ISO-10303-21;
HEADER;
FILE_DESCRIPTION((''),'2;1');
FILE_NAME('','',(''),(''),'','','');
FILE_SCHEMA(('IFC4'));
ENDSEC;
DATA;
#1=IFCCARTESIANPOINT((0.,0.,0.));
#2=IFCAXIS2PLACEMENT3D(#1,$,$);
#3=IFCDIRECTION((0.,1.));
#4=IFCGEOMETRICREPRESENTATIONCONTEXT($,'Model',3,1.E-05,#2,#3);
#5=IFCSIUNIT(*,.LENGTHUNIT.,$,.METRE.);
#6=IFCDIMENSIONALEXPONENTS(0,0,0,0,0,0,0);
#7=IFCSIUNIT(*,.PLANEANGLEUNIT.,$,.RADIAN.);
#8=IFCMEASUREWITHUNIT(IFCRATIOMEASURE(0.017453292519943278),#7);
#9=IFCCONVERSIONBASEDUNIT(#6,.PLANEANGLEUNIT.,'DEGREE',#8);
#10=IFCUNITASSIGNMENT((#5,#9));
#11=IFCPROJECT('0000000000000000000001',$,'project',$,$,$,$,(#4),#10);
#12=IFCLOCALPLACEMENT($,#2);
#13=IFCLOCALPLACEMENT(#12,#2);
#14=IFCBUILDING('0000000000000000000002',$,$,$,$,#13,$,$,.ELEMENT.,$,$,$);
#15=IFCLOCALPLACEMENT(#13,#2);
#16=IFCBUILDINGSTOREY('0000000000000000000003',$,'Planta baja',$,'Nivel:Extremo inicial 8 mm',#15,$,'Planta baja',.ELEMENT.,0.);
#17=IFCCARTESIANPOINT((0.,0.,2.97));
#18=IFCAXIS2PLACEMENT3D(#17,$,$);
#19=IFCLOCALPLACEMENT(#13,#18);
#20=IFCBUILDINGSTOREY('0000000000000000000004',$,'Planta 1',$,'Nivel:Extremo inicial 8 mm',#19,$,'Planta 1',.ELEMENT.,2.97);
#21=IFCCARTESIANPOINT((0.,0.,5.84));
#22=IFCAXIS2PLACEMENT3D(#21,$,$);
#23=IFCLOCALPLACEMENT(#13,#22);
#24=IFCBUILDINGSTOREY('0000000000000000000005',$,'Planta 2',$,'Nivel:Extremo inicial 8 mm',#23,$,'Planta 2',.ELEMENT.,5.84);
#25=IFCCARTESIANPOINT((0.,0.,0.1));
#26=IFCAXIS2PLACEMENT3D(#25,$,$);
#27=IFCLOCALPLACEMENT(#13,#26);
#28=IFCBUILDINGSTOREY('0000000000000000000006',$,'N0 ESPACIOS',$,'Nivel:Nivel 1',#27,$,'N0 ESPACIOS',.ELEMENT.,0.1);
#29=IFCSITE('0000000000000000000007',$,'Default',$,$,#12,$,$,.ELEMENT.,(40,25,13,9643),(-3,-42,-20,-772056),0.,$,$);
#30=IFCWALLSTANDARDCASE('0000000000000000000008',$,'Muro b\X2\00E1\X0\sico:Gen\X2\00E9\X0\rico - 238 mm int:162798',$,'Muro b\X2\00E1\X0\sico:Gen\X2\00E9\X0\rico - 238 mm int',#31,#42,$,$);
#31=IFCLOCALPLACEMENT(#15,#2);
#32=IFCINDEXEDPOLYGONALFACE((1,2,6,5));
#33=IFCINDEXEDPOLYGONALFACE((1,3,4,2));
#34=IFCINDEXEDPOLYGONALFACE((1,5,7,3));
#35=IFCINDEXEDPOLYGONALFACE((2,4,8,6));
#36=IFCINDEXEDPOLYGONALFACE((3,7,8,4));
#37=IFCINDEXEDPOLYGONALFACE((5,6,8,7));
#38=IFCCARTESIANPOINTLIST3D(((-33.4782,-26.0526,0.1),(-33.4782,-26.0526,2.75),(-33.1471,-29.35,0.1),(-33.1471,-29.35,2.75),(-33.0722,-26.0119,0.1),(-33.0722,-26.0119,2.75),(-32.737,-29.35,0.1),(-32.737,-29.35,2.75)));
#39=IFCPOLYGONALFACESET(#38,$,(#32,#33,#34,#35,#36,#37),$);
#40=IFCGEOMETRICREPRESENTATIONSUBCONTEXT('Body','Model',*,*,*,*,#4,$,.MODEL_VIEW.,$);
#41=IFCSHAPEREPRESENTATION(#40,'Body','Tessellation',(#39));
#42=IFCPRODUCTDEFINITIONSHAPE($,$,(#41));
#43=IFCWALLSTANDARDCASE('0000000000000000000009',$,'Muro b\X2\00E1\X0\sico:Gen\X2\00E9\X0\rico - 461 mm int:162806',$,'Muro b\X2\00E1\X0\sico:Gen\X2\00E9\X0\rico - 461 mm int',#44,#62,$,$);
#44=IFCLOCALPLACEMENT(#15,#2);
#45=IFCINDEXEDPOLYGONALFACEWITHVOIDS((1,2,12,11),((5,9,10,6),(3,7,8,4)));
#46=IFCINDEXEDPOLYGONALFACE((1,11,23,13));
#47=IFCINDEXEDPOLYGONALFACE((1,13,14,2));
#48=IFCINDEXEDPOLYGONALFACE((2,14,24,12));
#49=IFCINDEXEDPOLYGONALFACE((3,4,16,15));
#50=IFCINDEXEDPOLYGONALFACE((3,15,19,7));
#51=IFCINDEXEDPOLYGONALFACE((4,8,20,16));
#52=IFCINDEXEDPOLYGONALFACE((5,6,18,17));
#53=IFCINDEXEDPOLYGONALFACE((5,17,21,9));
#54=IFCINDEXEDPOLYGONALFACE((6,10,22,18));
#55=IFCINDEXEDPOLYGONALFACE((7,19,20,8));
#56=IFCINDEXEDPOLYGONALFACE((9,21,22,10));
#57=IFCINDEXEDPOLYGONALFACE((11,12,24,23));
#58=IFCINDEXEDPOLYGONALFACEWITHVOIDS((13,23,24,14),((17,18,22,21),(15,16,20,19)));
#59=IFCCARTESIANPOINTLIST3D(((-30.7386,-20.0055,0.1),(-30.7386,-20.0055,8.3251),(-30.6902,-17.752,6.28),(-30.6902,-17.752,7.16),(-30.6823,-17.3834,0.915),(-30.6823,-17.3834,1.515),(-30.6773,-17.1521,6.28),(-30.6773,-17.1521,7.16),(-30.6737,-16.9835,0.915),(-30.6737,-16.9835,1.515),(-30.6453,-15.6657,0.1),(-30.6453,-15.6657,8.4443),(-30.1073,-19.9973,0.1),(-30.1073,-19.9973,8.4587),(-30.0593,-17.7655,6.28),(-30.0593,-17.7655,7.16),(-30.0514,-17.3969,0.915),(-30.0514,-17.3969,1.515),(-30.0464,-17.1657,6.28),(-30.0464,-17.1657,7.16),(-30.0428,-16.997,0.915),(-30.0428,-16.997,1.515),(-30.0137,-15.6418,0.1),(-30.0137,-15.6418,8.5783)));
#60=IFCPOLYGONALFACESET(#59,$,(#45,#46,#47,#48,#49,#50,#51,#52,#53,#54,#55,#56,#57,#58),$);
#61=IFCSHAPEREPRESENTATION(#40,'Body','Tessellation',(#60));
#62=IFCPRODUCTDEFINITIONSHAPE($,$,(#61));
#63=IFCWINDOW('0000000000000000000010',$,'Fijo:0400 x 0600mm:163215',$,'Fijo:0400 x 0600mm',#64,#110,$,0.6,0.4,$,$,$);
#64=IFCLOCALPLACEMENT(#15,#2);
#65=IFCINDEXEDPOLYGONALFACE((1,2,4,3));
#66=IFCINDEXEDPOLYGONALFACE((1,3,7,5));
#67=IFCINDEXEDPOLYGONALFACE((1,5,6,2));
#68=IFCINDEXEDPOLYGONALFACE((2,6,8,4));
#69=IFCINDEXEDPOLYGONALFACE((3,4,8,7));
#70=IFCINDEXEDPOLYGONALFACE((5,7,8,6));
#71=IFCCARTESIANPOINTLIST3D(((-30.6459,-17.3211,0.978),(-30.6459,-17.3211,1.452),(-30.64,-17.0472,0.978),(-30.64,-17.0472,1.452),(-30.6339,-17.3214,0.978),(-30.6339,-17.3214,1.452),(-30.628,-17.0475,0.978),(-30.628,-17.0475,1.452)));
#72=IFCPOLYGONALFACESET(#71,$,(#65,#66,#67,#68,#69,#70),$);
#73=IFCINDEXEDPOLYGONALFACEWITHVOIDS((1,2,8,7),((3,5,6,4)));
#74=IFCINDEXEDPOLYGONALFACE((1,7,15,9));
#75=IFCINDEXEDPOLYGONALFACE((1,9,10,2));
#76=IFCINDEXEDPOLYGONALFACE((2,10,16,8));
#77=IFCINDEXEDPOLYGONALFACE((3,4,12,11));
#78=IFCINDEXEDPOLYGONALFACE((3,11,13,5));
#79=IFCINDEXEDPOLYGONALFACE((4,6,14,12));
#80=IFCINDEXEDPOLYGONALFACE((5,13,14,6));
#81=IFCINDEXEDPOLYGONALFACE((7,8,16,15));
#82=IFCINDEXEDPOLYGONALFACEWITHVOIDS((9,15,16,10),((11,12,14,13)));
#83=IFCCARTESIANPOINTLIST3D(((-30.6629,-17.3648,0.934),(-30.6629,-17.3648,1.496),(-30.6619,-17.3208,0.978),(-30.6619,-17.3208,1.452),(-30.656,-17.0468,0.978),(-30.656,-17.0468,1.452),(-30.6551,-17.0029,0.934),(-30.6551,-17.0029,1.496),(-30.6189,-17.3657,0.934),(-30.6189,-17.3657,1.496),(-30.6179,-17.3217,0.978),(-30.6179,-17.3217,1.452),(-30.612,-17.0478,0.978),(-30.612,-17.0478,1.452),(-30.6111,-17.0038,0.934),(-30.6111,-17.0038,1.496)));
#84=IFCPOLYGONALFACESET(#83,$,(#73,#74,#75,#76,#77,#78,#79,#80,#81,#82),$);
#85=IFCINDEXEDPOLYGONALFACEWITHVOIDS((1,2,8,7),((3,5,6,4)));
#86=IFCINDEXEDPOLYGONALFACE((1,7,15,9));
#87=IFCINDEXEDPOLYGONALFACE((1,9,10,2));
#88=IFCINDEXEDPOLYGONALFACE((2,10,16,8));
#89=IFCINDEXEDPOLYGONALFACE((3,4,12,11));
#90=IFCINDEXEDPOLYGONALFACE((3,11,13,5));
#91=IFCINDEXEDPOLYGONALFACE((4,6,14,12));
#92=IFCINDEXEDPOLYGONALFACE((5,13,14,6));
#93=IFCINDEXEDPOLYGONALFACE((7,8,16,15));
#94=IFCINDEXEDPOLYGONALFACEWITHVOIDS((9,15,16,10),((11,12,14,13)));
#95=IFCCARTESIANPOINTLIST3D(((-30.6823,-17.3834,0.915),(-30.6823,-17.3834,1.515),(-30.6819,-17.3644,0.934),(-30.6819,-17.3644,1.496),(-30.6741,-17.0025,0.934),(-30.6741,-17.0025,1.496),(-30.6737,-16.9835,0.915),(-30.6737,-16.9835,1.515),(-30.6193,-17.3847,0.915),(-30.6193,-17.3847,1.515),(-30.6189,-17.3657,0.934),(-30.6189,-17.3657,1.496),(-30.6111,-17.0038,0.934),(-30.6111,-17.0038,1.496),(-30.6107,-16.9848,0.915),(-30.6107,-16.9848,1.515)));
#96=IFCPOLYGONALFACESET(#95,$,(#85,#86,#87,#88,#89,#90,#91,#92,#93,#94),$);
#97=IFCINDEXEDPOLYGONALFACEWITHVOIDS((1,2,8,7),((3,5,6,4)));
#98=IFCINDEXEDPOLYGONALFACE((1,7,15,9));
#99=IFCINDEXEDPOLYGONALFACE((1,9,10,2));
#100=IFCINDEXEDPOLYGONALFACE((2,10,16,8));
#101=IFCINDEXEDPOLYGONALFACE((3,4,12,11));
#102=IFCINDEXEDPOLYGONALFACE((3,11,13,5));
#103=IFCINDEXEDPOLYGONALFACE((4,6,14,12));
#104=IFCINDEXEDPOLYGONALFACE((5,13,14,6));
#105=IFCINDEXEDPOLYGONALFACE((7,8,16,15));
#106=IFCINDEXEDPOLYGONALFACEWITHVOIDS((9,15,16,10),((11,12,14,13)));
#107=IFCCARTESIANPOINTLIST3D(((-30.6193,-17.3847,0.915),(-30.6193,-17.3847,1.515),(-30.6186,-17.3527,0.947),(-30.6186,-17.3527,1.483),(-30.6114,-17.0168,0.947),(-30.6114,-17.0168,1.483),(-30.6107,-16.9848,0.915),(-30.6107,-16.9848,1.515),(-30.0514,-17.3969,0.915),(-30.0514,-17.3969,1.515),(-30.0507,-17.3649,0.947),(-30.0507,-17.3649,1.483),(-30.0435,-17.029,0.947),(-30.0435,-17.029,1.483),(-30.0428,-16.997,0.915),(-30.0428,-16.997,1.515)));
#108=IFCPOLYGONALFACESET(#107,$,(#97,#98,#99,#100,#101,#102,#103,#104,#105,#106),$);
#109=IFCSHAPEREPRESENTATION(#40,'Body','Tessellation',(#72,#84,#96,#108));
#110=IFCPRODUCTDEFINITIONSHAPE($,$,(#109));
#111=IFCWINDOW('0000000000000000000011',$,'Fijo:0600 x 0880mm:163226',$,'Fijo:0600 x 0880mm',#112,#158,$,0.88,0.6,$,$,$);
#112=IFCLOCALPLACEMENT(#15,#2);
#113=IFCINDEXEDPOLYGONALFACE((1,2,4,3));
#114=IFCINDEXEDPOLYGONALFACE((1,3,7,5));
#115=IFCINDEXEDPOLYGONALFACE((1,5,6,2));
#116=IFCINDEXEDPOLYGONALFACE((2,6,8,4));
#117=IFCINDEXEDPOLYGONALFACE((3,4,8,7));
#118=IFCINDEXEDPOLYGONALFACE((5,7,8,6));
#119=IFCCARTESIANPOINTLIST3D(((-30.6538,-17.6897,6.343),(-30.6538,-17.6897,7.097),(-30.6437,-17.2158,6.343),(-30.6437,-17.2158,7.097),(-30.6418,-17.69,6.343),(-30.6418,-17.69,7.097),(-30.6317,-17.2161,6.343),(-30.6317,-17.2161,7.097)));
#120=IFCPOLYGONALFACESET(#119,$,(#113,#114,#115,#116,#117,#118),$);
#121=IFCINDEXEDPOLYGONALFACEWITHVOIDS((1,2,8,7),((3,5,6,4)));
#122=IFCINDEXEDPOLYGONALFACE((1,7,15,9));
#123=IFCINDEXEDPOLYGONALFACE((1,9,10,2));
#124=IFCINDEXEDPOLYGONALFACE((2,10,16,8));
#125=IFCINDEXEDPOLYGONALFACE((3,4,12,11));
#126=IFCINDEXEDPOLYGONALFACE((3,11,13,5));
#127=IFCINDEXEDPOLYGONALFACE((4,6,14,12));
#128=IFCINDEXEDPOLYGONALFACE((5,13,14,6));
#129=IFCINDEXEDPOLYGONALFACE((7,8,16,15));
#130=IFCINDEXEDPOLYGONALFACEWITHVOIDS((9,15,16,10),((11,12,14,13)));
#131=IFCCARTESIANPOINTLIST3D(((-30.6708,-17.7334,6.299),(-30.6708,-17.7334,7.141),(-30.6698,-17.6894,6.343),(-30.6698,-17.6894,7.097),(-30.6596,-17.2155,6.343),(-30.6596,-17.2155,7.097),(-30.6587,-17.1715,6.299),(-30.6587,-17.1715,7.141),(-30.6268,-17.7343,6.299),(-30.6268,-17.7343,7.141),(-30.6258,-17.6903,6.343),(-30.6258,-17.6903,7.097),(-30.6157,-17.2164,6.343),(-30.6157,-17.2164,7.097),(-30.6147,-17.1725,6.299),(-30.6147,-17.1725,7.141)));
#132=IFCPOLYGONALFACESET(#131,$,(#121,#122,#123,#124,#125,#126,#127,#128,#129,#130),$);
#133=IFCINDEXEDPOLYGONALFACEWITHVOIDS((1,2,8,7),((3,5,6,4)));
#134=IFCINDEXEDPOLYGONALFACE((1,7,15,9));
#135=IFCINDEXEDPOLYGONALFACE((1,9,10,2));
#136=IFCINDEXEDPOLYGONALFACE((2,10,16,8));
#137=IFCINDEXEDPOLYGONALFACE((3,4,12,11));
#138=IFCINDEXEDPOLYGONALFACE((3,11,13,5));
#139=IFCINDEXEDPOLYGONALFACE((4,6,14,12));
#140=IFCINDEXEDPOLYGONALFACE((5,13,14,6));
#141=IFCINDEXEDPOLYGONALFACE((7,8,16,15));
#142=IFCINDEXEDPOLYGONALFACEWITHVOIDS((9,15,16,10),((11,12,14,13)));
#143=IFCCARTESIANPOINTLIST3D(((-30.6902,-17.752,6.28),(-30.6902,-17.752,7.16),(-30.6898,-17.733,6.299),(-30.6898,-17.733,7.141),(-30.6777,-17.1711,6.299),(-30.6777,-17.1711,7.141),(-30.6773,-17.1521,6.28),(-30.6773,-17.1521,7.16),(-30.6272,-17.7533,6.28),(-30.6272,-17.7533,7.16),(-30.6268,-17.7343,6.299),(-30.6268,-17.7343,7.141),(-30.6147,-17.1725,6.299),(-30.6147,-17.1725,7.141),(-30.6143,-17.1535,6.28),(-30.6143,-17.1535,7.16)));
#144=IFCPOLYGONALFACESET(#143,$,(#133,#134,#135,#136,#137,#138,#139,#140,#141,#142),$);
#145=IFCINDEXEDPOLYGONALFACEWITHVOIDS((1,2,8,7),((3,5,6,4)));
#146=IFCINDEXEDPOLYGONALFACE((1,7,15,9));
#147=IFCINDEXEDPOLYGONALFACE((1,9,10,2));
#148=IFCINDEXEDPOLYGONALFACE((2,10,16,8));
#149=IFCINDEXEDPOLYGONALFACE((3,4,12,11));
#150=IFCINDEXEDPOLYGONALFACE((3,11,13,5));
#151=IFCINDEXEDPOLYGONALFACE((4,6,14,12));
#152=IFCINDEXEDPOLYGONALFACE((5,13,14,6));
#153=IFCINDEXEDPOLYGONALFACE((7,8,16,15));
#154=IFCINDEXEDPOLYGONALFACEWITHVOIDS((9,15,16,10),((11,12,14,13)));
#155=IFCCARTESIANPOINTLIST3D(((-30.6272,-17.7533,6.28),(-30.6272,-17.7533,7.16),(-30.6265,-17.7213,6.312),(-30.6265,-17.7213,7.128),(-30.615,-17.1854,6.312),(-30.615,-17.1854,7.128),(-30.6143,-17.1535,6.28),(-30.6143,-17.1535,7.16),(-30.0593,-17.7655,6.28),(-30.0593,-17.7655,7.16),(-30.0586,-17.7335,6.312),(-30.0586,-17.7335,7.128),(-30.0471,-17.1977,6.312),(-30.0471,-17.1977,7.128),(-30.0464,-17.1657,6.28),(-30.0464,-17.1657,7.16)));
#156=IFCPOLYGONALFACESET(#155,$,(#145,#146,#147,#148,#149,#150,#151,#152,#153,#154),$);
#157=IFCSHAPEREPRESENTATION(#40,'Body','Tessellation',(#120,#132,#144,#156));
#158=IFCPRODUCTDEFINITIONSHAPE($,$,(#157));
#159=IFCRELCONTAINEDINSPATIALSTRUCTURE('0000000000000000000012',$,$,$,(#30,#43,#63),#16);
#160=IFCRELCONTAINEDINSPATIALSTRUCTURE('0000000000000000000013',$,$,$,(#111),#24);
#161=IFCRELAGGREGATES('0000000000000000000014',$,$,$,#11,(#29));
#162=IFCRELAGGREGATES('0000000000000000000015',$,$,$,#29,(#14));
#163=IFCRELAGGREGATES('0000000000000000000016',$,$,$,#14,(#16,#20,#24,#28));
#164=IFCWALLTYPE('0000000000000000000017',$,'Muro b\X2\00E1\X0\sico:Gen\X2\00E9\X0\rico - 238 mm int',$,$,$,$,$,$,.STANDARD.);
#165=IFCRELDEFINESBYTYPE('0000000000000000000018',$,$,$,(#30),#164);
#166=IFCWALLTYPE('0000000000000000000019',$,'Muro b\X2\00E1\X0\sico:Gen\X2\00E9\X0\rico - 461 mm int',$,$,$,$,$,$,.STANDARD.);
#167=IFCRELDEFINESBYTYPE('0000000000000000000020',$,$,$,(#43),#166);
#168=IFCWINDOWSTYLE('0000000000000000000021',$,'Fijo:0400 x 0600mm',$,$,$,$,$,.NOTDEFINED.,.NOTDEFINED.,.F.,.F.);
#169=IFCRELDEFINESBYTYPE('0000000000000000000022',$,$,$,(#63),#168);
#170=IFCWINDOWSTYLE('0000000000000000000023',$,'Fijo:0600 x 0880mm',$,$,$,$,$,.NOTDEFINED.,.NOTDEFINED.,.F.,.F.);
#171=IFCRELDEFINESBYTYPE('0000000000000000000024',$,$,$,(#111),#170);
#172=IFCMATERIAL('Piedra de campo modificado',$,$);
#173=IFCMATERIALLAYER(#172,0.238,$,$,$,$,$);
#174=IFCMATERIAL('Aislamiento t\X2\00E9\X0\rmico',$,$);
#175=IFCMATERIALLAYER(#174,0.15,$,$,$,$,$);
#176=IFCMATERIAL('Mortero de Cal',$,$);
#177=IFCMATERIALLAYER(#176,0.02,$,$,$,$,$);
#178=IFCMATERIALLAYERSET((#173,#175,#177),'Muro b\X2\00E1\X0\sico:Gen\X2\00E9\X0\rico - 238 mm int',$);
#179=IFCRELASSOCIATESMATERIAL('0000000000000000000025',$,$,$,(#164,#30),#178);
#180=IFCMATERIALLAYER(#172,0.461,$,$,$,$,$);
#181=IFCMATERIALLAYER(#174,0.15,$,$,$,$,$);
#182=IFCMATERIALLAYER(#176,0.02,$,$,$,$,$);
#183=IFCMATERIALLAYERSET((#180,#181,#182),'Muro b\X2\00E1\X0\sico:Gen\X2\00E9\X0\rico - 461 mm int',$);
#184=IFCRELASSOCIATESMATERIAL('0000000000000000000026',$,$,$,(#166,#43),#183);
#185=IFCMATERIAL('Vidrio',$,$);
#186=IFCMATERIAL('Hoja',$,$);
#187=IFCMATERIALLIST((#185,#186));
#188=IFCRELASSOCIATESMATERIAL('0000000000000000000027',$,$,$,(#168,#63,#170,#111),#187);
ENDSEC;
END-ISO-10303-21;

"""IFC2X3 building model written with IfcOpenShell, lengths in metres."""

from ifc_helpers import new_model, entity, si_unit, converted_unit, direction, frame, frame_2d, origin, origin_2d_with_axis, place, context, subcontext, project, spatial, polyline, rectangle, outline, extrude, clip, bounded_halfspace, source, transform, mapped, material, material_list, layer, layer_set, layer_usage, type_object, type_shapes, element, fill, save


model = new_model("IFC2X3")

# Units and contexts
model_context = context("Model", 3, precision=1e-05, world=origin(), true_north=direction((0.0, 1.0)))
body_context = subcontext(model_context, "Body", "Model", "MODEL_VIEW")
ifc_project = project(units=[si_unit("LENGTHUNIT", "METRE"), converted_unit("PLANEANGLEUNIT", "DEGREE", entity("IfcRatioMeasure", 0.017453292519943278), si_unit("PLANEANGLEUNIT", "RADIAN"), dimensions=[0, 0, 0, 0, 0, 0, 0])], contexts=[model_context])

# Site, building, storey
site_placement = place(None, origin())
site = spatial("IfcSite", under=ifc_project, at=site_placement, Name="Default", CompositionType="ELEMENT", RefLatitude=(40, 25, 13, 9643), RefLongitude=(-3, -42, -20, -772056), RefElevation=0.0)
building_placement = place(site_placement, origin())
building = spatial("IfcBuilding", under=site, at=building_placement, CompositionType="ELEMENT")
storey_1_placement = place(building_placement, origin())
storey_1 = spatial("IfcBuildingStorey", under=building, at=storey_1_placement, Name="Planta baja", ObjectType="Nivel:Extremo inicial 8 mm", LongName="Planta baja", CompositionType="ELEMENT", Elevation=0.0)

# Shared definitions
ifc_material_1 = material(Name="Piedra de campo modificado")
ifc_material_2 = material(Name="Aislamiento térmico")
ifc_material_3 = material(Name="Mortero de Cal")

# Shared definitions
storey_2_placement = place(building_placement, frame((0.0, 0.0, 2.97)))
storey_2 = spatial("IfcBuildingStorey", under=building, at=storey_2_placement, Name="Planta 1", ObjectType="Nivel:Extremo inicial 8 mm", LongName="Planta 1", CompositionType="ELEMENT", Elevation=2.97)

# Shared definitions
ifc_material_4 = material(Name="Vidrio")
ifc_material_5 = material(Name="Hoja")
ifc_material_list_1 = material_list([ifc_material_4, ifc_material_5])

# Shared definitions
storey_3_placement = place(building_placement, frame((0.0, 0.0, 5.84)))
storey_3 = spatial("IfcBuildingStorey", under=building, at=storey_3_placement, Name="Planta 2", ObjectType="Nivel:Extremo inicial 8 mm", LongName="Planta 2", CompositionType="ELEMENT", Elevation=5.84)

# Wall
ifc_layer_1 = layer(ifc_material_1, 0.238)
ifc_layer_2 = layer(ifc_material_2, 0.15)
ifc_layer_3 = layer(ifc_material_3, 0.02)
ifc_layer_set_1 = layer_set([ifc_layer_1, ifc_layer_2, ifc_layer_3], Name="Muro básico:Genérico - 238 mm int")
ifc_layer_usage_1 = layer_usage(ifc_layer_set_1, "AXIS2", "NEGATIVE", 0.204)
wall_type_1 = type_object("IfcWallType", Name="Muro básico:Genérico - 238 mm int", PredefinedType="STANDARD", material=ifc_layer_set_1)
wall_1_placement = place(storey_1_placement, frame((-33.2752, -26.0322, 0.1), z_axis=(0.0, 0.0, 1.0), x_axis=(0.09992, -0.994996, 0.0)))
element("IfcWallStandardCase", 1, at=wall_1_placement, inside=storey_1, type_object=wall_type_1, material=ifc_layer_usage_1, Name="Muro básico:Genérico - 238 mm int:162798", ObjectType="Muro básico:Genérico - 238 mm int", context=body_context, shape_type="Clipping", body=[
    clip(extrude(outline(polyline([(3.314, -0.204), (3.355, 0.204), (2.8625, 0.204), (0.0, 0.204), (0.0, -0.204), (3.314, -0.204)])), origin(), (0.0, 0.0, 1.0), 2.65), bounded_halfspace(frame((0.0216, -0.204, 2.65), z_axis=(0.0, 0.0, -1.0), x_axis=(-1.0, 0.0, 0.0)), True, frame((0.0216, -0.204, 2.65)), polyline([(0.0, 0.0), (3.2924, 0.0), (3.3334, 0.408), (2.8409, 0.408), (0.0485, 0.408), (0.0, 0.0)]))),
])

# Shared definitions
storey_4_placement = place(building_placement, frame((0.0, 0.0, 0.1)))
storey_4 = spatial("IfcBuildingStorey", under=building, at=storey_4_placement, Name="N0 ESPACIOS", ObjectType="Nivel:Nivel 1", LongName="N0 ESPACIOS", CompositionType="ELEMENT", Elevation=0.1)

# Wall, openings, windows
ifc_layer_4 = layer(ifc_material_1, 0.461)
ifc_layer_5 = layer(ifc_material_2, 0.15)
ifc_layer_6 = layer(ifc_material_3, 0.02)
ifc_layer_set_2 = layer_set([ifc_layer_4, ifc_layer_5, ifc_layer_6], Name="Muro básico:Genérico - 461 mm int")
ifc_layer_usage_2 = layer_usage(ifc_layer_set_2, "AXIS2", "NEGATIVE", 0.3155)
wall_type_2 = type_object("IfcWallType", Name="Muro básico:Genérico - 461 mm int", PredefinedType="STANDARD", material=ifc_layer_set_2)
wall_2_placement = place(storey_1_placement, frame((-30.3291, -15.6351, 0.1), z_axis=(0.0, 0.0, 1.0), x_axis=(-0.021499, -0.999769, 0.0)))
wall_2 = element("IfcWallStandardCase", 2, at=wall_2_placement, inside=storey_1, type_object=wall_type_2, material=ifc_layer_usage_2, Name="Muro básico:Genérico - 461 mm int:162806", ObjectType="Muro básico:Genérico - 461 mm int", context=body_context, shape_type="Clipping", body=[
    clip(extrude(outline(polyline([(4.3782, -0.3155), (4.3564, 0.3155), (0.4508, 0.3155), (0.0, 0.3155), (0.0374, -0.3155), (4.3782, -0.3155)])), origin(), (0.0, 0.0, 1.0), 8.4783), bounded_halfspace(frame((0.0374, -0.3155, 8.3443), z_axis=(0.026843, -0.206172, 0.978148), x_axis=(0.991631, 0.129107, 0.0)), False, frame((0.0374, -0.3155, 8.3443)), polyline([(0.0, 0.0), (3.6083, 0.0), (4.3408, 0.0), (4.319, 0.631), (0.4134, 0.631), (-0.0374, 0.631), (0.0, 0.0)]))),
])
opening_1_placement = place(wall_2_placement, frame((1.7555, 0.3155, 0.815)))
opening_1 = element("IfcOpeningElement", 3, at=opening_1_placement, cuts=wall_2, ObjectType="Opening", context=body_context, shape_type="SweptSolid", body=[
    extrude(rectangle(XDim=0.6, YDim=0.4, at=frame_2d((0.3, 0.2), x_axis=(1.0, 0.0))), frame((0.0, 0.0, 0.0), z_axis=(0.0, -1.0, 0.0), x_axis=(0.0, 0.0, 1.0)), (0.0, 0.0, 1.0), 0.631),
])
opening_2_placement = place(wall_2_placement, frame((2.1242, 0.3155, 6.18)))
opening_2 = element("IfcOpeningElement", 4, at=opening_2_placement, cuts=wall_2, ObjectType="Opening", context=body_context, shape_type="SweptSolid", body=[
    extrude(rectangle(XDim=0.88, YDim=0.6, at=frame_2d((0.44, 0.3), x_axis=(1.0, 0.0))), frame((0.0, 0.0, 0.0), z_axis=(0.0, -1.0, 0.0), x_axis=(0.0, 0.0, 1.0)), (0.0, 0.0, 1.0), 0.631),
])
window_style_1 = type_object("IfcWindowStyle", Name="Fijo:0400 x 0600mm", ConstructionType="NOTDEFINED", OperationType="NOTDEFINED", ParameterTakesPrecedence=False, Sizeable=False, material=ifc_material_list_1)
shared_shape_1 = source(origin(), body_context, "Body", "SweptSolid", [
    extrude(rectangle(XDim=0.012, YDim=0.274, at=origin_2d_with_axis()), frame((0.2, 0.59, 0.063), z_axis=(0.0, 0.0, 1.0), x_axis=(0.0, -1.0, 0.0)), (0.0, 0.0, 1.0), 0.474),
    extrude(outline(polyline([(-0.181, -0.281), (0.181, -0.281), (0.181, 0.281), (-0.181, 0.281), (-0.181, -0.281)]), holes=[polyline([(-0.137, -0.237), (-0.137, 0.237), (0.137, 0.237), (0.137, -0.237), (-0.137, -0.237)])]), frame((0.2, 0.568, 0.3), z_axis=(0.0, 1.0, 0.0), x_axis=(1.0, 0.0, 0.0)), (0.0, 0.0, 1.0), 0.044),
    extrude(outline(polyline([(-0.2, -0.3), (0.2, -0.3), (0.2, 0.3), (-0.2, 0.3), (-0.2, -0.3)]), holes=[polyline([(-0.181, -0.281), (-0.181, 0.281), (0.181, 0.281), (0.181, -0.281), (-0.181, -0.281)])]), frame((0.2, 0.568, 0.3), z_axis=(0.0, 1.0, 0.0), x_axis=(1.0, 0.0, 0.0)), (0.0, 0.0, 1.0), 0.063),
    extrude(outline(polyline([(-0.2, -0.3), (0.2, -0.3), (0.2, 0.3), (-0.2, 0.3), (-0.2, -0.3)]), holes=[polyline([(-0.168, -0.268), (-0.168, 0.268), (0.168, 0.268), (0.168, -0.268), (-0.168, -0.268)])]), frame((0.2, 0.0, 0.3), z_axis=(0.0, 1.0, 0.0), x_axis=(1.0, 0.0, 0.0)), (0.0, 0.0, 1.0), 0.568),
])
type_shapes(window_style_1, [shared_shape_1])
window_1_placement = place(opening_1_placement, frame((0.0, 0.0, 0.0), z_axis=(0.0, 0.0, 1.0), x_axis=(-1.0, 0.0, 0.0)))
window_1 = element("IfcWindow", 5, at=window_1_placement, inside=storey_1, type_object=window_style_1, material=ifc_material_list_1, Name="Fijo:0400 x 0600mm:163215", ObjectType="Fijo:0400 x 0600mm", OverallHeight=0.6, OverallWidth=0.4, context=body_context, shape_type="MappedRepresentation", body=[
    mapped(shared_shape_1, transform((0.0, 0.0, 0.0), scale=1.0)),
])
fill(opening_1, window_1)
window_style_2 = type_object("IfcWindowStyle", Name="Fijo:0600 x 0880mm", ConstructionType="NOTDEFINED", OperationType="NOTDEFINED", ParameterTakesPrecedence=False, Sizeable=False, material=ifc_material_list_1)
shared_shape_2 = source(origin(), body_context, "Body", "SweptSolid", [
    extrude(rectangle(XDim=0.012, YDim=0.474, at=origin_2d_with_axis()), frame((0.3, 0.59, 0.063), z_axis=(0.0, 0.0, 1.0), x_axis=(0.0, -1.0, 0.0)), (0.0, 0.0, 1.0), 0.754),
    extrude(outline(polyline([(-0.281, -0.421), (0.281, -0.421), (0.281, 0.421), (-0.281, 0.421), (-0.281, -0.421)]), holes=[polyline([(-0.237, -0.377), (-0.237, 0.377), (0.237, 0.377), (0.237, -0.377), (-0.237, -0.377)])]), frame((0.3, 0.568, 0.44), z_axis=(0.0, 1.0, 0.0), x_axis=(1.0, 0.0, 0.0)), (0.0, 0.0, 1.0), 0.044),
    extrude(outline(polyline([(-0.3, -0.44), (0.3, -0.44), (0.3, 0.44), (-0.3, 0.44), (-0.3, -0.44)]), holes=[polyline([(-0.281, -0.421), (-0.281, 0.421), (0.281, 0.421), (0.281, -0.421), (-0.281, -0.421)])]), frame((0.3, 0.568, 0.44), z_axis=(0.0, 1.0, 0.0), x_axis=(1.0, 0.0, 0.0)), (0.0, 0.0, 1.0), 0.063),
    extrude(outline(polyline([(-0.3, -0.44), (0.3, -0.44), (0.3, 0.44), (-0.3, 0.44), (-0.3, -0.44)]), holes=[polyline([(-0.268, -0.408), (-0.268, 0.408), (0.268, 0.408), (0.268, -0.408), (-0.268, -0.408)])]), frame((0.3, 0.0, 0.44), z_axis=(0.0, 1.0, 0.0), x_axis=(1.0, 0.0, 0.0)), (0.0, 0.0, 1.0), 0.568),
])
type_shapes(window_style_2, [shared_shape_2])
window_2_placement = place(opening_2_placement, frame((0.0, 0.0, 0.0), z_axis=(0.0, 0.0, 1.0), x_axis=(-1.0, 0.0, 0.0)))
window_2 = element("IfcWindow", 6, at=window_2_placement, inside=storey_3, type_object=window_style_2, material=ifc_material_list_1, Name="Fijo:0600 x 0880mm:163226", ObjectType="Fijo:0600 x 0880mm", OverallHeight=0.88, OverallWidth=0.6, context=body_context, shape_type="MappedRepresentation", body=[
    mapped(shared_shape_2, transform((0.0, 0.0, 0.0), scale=1.0)),
])
fill(opening_2, window_2)

save(model, "model.ifc")
